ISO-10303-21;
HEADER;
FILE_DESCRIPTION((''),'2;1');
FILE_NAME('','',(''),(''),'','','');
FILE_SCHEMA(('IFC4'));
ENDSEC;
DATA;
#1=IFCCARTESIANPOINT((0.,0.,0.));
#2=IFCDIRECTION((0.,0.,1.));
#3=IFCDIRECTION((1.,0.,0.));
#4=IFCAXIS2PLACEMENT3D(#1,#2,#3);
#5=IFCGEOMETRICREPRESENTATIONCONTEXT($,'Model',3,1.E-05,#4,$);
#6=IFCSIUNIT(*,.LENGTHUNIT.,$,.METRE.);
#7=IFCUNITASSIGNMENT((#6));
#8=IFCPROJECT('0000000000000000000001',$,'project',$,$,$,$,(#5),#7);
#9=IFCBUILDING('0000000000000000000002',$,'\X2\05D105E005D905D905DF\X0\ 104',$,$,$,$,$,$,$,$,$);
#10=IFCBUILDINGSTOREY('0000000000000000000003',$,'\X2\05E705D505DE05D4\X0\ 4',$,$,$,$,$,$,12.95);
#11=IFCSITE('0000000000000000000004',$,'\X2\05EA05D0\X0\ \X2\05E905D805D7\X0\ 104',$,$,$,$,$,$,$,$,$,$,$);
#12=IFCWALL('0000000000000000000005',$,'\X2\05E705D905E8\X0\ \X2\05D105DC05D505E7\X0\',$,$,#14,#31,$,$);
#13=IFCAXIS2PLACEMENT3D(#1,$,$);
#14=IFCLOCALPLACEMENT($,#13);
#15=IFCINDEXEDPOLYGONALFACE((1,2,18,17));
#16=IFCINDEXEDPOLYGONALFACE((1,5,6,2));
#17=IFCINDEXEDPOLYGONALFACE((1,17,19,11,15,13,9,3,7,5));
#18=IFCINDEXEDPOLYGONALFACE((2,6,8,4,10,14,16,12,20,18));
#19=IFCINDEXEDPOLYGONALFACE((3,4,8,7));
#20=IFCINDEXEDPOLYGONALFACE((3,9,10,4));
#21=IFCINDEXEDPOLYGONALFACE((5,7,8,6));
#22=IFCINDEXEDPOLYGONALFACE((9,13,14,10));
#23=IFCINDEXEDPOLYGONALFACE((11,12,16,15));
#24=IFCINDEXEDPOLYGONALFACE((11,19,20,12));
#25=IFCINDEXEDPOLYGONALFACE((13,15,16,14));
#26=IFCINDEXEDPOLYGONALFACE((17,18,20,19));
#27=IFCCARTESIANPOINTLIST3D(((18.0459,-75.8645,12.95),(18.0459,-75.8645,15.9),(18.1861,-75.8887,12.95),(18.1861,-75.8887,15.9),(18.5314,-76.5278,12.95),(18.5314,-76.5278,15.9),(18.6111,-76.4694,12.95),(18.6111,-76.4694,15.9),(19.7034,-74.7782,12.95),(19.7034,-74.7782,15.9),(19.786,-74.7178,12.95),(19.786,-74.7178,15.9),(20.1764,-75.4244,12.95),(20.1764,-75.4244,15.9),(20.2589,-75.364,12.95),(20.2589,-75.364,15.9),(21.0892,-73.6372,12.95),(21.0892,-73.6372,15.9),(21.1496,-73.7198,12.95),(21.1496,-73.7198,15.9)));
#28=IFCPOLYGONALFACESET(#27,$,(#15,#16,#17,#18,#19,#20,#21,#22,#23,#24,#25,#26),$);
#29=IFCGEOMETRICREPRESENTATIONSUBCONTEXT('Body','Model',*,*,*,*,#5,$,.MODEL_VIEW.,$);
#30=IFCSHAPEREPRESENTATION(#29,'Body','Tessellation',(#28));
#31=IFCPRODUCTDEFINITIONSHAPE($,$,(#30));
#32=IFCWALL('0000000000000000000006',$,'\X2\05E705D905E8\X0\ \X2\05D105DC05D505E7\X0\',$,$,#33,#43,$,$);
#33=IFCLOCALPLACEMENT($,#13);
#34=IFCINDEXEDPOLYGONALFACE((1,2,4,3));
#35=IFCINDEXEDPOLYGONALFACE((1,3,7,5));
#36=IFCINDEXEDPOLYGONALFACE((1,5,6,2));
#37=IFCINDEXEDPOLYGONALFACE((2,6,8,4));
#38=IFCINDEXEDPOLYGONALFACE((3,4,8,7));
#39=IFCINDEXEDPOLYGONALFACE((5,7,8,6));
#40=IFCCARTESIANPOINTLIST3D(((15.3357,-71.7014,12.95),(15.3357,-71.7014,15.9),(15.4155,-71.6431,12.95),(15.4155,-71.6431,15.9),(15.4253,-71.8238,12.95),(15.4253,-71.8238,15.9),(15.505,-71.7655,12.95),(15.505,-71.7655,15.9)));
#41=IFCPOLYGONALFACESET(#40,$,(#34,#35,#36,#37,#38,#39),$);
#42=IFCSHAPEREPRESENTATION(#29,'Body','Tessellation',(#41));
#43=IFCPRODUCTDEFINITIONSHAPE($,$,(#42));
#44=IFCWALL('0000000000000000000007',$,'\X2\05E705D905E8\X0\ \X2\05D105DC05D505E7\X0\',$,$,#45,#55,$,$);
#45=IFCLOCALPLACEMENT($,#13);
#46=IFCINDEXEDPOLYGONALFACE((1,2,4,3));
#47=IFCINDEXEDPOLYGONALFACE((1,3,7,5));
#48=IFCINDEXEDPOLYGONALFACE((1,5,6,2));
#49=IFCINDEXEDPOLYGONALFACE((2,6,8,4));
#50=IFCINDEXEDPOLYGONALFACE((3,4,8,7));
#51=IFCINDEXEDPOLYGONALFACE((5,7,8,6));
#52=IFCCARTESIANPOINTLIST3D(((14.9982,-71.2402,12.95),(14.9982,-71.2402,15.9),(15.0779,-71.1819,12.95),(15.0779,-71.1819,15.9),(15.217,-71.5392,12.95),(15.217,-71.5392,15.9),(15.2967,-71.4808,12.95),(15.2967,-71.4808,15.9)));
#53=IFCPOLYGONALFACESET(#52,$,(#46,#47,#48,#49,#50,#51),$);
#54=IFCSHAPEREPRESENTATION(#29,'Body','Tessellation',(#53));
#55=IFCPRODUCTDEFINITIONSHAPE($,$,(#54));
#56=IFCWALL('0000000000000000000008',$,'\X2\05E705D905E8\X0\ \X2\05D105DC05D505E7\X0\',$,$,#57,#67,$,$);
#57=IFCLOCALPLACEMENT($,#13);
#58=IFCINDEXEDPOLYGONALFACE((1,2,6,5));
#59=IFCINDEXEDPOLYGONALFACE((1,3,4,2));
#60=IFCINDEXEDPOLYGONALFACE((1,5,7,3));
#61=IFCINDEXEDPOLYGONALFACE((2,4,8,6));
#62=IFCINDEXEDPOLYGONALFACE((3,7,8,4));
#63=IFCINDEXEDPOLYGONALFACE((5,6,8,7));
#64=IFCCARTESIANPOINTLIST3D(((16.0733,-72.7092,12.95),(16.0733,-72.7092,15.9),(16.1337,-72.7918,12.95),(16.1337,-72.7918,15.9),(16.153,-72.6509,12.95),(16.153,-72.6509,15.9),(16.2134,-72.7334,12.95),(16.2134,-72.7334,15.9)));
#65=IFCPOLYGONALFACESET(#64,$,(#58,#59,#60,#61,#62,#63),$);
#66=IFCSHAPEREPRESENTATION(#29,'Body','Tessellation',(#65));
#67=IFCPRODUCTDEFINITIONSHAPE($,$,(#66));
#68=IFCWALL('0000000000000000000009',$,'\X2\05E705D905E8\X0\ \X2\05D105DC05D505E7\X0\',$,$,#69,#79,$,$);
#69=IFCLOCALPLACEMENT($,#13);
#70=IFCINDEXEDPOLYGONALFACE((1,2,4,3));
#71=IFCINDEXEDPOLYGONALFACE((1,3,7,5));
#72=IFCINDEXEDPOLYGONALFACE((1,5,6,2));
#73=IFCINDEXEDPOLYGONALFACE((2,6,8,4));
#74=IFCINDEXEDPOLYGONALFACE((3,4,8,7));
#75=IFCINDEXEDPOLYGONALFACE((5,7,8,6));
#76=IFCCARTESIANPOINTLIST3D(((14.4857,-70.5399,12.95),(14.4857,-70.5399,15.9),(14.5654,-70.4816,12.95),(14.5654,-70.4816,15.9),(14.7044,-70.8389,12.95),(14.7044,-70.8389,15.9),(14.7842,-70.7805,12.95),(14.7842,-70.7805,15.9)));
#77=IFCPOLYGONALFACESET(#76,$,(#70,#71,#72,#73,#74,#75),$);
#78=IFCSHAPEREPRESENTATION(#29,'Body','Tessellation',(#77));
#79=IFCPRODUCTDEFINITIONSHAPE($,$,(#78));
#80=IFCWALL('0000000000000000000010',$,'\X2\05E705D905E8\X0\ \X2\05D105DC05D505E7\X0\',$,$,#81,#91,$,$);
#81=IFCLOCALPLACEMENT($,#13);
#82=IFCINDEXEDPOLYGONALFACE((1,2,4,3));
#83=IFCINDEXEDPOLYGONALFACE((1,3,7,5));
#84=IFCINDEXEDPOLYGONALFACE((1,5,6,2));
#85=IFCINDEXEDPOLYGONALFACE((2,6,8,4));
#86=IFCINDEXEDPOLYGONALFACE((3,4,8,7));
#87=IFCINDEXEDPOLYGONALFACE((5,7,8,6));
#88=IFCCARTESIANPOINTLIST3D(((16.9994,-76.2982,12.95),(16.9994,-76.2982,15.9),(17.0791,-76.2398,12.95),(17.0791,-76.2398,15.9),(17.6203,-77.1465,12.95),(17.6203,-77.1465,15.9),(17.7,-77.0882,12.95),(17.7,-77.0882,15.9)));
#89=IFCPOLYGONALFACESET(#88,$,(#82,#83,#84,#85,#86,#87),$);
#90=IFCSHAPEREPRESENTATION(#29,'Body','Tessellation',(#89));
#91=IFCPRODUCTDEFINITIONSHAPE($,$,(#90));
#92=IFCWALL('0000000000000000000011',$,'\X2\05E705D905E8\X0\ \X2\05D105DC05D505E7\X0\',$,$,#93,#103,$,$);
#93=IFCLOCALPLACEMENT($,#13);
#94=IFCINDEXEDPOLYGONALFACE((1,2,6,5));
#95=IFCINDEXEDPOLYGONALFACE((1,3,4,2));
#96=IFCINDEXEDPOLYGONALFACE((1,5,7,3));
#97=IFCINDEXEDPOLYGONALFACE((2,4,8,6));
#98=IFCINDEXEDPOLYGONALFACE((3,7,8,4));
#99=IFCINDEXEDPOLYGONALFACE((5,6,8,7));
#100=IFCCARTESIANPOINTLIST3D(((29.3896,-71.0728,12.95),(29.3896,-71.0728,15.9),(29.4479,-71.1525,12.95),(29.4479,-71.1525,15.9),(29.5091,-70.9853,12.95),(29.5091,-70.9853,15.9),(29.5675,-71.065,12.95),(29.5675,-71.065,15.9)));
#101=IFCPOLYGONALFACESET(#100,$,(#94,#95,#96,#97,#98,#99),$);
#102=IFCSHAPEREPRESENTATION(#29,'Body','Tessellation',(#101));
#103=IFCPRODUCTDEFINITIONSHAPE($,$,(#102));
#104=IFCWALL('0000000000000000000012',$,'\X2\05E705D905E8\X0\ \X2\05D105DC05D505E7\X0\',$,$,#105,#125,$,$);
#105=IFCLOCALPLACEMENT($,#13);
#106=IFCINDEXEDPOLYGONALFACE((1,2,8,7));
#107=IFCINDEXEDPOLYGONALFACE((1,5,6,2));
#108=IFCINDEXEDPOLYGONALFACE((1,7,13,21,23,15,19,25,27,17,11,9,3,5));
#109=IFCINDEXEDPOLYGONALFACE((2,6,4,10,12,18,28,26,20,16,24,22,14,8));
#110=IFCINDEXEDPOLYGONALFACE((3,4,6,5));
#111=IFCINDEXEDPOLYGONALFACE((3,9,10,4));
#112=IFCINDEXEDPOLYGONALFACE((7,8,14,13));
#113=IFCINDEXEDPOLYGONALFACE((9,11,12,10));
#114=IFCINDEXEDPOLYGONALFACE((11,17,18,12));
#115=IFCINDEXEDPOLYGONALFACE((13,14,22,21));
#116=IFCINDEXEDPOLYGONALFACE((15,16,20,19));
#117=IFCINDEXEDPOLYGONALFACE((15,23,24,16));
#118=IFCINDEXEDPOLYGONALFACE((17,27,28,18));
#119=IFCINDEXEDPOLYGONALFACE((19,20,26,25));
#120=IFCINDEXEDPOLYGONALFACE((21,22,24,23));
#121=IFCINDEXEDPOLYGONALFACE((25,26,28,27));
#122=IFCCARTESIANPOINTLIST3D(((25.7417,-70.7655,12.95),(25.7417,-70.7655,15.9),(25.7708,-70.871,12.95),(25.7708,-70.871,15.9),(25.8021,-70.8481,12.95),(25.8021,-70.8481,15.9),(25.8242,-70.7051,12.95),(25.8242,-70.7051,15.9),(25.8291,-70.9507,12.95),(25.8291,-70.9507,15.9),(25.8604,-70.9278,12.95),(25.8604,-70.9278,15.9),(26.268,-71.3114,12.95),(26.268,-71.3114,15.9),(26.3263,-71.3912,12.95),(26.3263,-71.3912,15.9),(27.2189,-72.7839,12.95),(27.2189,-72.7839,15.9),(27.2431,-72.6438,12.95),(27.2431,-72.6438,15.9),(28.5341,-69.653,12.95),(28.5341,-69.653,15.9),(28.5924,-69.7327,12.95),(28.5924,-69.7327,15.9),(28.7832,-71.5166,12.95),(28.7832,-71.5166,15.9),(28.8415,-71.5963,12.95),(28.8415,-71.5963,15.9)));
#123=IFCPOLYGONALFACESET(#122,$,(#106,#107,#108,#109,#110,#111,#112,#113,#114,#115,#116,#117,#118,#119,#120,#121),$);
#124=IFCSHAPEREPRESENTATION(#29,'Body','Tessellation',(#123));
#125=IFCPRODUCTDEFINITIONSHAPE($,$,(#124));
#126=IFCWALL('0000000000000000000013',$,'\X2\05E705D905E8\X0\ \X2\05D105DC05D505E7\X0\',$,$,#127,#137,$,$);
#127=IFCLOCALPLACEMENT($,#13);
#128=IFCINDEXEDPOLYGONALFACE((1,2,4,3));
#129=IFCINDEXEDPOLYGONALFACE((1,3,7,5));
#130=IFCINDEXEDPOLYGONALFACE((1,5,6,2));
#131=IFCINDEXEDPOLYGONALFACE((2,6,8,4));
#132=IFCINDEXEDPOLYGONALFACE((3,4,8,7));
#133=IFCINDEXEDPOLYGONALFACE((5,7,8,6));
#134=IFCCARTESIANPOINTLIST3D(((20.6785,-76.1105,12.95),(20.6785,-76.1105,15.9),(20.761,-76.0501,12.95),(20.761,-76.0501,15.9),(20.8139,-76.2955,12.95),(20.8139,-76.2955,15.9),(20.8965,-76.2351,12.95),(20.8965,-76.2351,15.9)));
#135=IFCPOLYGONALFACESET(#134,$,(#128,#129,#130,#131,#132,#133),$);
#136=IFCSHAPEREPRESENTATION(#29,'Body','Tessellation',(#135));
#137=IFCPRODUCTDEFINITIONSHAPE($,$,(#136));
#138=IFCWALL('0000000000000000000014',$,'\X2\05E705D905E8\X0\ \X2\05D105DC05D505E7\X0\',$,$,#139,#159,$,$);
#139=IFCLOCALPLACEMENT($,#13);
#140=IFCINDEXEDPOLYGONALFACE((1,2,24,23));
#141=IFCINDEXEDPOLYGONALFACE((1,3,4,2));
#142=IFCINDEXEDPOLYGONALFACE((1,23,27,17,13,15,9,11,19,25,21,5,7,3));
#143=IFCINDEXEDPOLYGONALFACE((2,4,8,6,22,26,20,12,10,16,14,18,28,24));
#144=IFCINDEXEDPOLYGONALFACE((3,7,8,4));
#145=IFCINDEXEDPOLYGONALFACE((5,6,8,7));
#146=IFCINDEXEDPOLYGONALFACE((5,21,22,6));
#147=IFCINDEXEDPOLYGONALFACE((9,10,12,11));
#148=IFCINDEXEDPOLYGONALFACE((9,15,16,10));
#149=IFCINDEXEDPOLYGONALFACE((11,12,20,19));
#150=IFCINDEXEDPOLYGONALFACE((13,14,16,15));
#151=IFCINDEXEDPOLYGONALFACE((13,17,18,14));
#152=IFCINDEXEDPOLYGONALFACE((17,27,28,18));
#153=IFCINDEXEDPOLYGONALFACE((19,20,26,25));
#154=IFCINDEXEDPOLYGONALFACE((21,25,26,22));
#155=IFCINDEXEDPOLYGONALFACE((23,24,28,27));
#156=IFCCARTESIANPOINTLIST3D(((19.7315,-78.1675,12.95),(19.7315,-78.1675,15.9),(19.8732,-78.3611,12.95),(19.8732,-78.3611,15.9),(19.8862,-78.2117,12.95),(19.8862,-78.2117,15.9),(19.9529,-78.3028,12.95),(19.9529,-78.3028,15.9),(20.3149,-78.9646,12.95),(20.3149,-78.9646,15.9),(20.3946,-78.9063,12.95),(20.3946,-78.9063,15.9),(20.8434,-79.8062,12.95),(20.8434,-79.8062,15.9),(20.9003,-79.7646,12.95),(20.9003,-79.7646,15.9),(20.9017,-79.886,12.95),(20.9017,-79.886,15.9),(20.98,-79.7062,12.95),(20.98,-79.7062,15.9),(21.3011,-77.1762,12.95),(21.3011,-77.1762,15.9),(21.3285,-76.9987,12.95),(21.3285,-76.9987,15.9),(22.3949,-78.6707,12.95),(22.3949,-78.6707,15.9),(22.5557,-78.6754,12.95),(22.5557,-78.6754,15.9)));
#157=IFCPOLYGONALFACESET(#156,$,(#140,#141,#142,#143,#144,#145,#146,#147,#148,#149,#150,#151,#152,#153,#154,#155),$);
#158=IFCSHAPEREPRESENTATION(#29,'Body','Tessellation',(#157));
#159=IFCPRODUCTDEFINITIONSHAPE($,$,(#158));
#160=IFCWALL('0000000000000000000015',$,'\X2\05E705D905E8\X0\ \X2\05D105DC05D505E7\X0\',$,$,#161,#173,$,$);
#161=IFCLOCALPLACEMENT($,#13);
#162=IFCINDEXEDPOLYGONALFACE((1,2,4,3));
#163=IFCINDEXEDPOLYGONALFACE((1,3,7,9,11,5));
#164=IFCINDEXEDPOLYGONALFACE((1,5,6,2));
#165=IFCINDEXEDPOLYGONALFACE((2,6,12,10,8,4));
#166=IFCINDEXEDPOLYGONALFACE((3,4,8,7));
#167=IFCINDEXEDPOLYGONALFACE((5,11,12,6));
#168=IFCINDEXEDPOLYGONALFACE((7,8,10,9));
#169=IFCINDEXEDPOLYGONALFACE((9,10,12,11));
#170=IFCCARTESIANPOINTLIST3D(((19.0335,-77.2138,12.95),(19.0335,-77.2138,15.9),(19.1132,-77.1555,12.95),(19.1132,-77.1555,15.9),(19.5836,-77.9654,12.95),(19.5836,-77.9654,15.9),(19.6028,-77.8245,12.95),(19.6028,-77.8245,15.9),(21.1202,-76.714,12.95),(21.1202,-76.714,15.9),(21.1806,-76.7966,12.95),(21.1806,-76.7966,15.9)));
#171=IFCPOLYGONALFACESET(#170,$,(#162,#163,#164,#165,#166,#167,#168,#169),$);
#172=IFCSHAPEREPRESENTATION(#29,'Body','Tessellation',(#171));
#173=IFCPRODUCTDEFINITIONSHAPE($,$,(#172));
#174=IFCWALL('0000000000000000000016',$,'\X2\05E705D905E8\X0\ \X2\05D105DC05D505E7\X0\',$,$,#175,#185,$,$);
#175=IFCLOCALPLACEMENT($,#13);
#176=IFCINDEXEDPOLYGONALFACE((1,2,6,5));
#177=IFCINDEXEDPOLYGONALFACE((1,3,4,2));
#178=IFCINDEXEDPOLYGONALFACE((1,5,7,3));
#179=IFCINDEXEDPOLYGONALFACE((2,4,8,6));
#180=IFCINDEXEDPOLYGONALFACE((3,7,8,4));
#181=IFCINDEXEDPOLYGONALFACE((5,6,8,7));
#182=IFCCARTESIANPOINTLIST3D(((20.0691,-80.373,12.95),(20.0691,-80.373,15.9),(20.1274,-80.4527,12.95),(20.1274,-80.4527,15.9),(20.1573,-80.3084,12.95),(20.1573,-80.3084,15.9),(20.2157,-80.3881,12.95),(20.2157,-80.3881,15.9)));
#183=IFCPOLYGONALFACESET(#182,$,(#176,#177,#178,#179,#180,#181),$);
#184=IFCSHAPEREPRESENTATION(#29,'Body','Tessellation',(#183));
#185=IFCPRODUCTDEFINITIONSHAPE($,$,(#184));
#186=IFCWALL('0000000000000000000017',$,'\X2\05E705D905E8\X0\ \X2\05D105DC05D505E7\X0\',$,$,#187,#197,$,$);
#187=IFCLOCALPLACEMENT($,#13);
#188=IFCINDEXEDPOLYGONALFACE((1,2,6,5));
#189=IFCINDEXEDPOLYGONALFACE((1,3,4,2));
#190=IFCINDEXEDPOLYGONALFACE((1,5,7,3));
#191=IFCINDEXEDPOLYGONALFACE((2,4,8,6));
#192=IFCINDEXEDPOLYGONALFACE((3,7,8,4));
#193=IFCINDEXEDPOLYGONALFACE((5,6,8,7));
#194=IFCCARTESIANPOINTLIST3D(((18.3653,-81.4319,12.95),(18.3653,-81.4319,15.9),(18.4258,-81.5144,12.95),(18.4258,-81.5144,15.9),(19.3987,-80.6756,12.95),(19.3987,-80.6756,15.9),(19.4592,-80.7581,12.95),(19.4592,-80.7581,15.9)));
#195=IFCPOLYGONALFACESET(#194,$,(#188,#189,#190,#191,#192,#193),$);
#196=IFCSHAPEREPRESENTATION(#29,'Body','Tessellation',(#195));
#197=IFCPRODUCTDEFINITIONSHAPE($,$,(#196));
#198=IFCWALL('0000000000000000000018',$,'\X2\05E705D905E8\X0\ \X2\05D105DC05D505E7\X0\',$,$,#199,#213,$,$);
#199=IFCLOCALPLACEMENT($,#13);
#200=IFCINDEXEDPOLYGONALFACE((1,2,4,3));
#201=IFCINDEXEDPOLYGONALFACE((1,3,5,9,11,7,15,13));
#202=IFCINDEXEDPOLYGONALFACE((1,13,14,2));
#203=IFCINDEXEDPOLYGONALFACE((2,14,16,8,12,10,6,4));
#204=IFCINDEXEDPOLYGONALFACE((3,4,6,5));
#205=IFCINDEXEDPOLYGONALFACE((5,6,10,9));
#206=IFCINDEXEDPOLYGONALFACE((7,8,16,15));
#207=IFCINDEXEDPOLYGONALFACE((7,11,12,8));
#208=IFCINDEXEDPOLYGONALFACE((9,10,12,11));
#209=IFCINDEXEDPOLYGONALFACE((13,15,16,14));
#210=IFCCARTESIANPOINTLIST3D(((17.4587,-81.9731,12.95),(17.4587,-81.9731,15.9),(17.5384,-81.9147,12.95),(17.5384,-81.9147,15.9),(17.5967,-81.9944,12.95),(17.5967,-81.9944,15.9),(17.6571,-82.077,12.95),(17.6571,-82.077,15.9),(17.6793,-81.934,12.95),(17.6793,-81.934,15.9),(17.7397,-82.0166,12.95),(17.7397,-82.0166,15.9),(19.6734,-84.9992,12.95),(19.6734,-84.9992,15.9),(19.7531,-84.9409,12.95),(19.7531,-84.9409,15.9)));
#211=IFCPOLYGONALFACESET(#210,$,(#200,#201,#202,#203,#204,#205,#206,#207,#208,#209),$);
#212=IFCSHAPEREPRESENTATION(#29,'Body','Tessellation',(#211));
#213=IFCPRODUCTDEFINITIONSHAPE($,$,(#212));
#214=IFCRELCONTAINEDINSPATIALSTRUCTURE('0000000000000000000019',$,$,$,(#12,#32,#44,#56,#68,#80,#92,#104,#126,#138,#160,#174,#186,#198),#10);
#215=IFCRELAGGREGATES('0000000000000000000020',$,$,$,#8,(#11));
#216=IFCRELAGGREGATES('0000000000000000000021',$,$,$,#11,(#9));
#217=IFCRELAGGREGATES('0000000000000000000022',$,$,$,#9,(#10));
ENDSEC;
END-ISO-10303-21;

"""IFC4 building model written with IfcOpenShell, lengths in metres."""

from ifc_helpers import new_model, si_unit, frame, origin_with_axes, context, subcontext, project, spatial, polyline, outline, extrude, element, save


model = new_model("IFC4")

# Units and contexts
model_context = context("Model", 3, precision=1e-05, world=origin_with_axes())
body_context = subcontext(model_context, "Body", "Model", "MODEL_VIEW")
ifc_project = project(units=[si_unit("LENGTHUNIT", "METRE")], contexts=[model_context])

# Site, building, storey
site = spatial("IfcSite", under=ifc_project, Name="תא שטח 104")
building = spatial("IfcBuilding", under=site, Name="בניין 104")
storey = spatial("IfcBuildingStorey", under=building, Name="קומה 4", Elevation=12.95)

# Walls
element("IfcWall", 1, inside=storey, Name="קיר בלוק", context=body_context, shape_type="SweptSolid", body=[
    extrude(outline(polyline([(19.7034, -74.7782), (20.1764, -75.4244), (20.2589, -75.364), (19.786, -74.7178), (21.1496, -73.7198), (21.0892, -73.6372), (18.0459, -75.8645), (18.5314, -76.5278), (18.6111, -76.4694), (18.1861, -75.8887), (19.7034, -74.7782)])), frame((0.0, 0.0, 12.95)), (0.0, 0.0, 1.0), 2.95),
])
element("IfcWall", 2, inside=storey, Name="קיר בלוק", context=body_context, shape_type="SweptSolid", body=[
    extrude(outline(polyline([(15.3357, -71.7014), (15.4253, -71.8238), (15.505, -71.7655), (15.4155, -71.6431), (15.3357, -71.7014)])), frame((0.0, 0.0, 12.95)), (0.0, 0.0, 1.0), 2.95),
])
element("IfcWall", 3, inside=storey, Name="קיר בלוק", context=body_context, shape_type="SweptSolid", body=[
    extrude(outline(polyline([(15.0779, -71.1819), (14.9982, -71.2403), (15.217, -71.5392), (15.2967, -71.4808), (15.0779, -71.1819)])), frame((0.0, 0.0, 12.95)), (0.0, 0.0, 1.0), 2.95),
])
element("IfcWall", 4, inside=storey, Name="קיר בלוק", context=body_context, shape_type="SweptSolid", body=[
    extrude(outline(polyline([(16.2134, -72.7334), (16.153, -72.6509), (16.0733, -72.7092), (16.1337, -72.7918), (16.2134, -72.7334)])), frame((0.0, 0.0, 12.95)), (0.0, 0.0, 1.0), 2.95),
])
element("IfcWall", 5, inside=storey, Name="קיר בלוק", context=body_context, shape_type="SweptSolid", body=[
    extrude(outline(polyline([(14.7044, -70.8389), (14.7841, -70.7805), (14.5654, -70.4816), (14.4857, -70.5399), (14.7044, -70.8389)])), frame((0.0, 0.0, 12.95)), (0.0, 0.0, 1.0), 2.95),
])
element("IfcWall", 6, inside=storey, Name="קיר בלוק", context=body_context, shape_type="SweptSolid", body=[
    extrude(outline(polyline([(17.6203, -77.1465), (17.7, -77.0882), (17.0791, -76.2398), (16.9994, -76.2982), (17.6203, -77.1465)])), frame((0.0, 0.0, 12.95)), (0.0, 0.0, 1.0), 2.95),
])
element("IfcWall", 7, inside=storey, Name="קיר בלוק", context=body_context, shape_type="SweptSolid", body=[
    extrude(outline(polyline([(29.5675, -71.065), (29.5091, -70.9853), (29.3896, -71.0728), (29.4479, -71.1525), (29.5675, -71.065)])), frame((0.0, 0.0, 12.95)), (0.0, 0.0, 1.0), 2.95),
])
element("IfcWall", 8, inside=storey, Name="קיר בלוק", context=body_context, shape_type="SweptSolid", body=[
    extrude(outline(polyline([(25.8021, -70.8481), (25.7708, -70.871), (25.8291, -70.9507), (25.8604, -70.9278), (27.2189, -72.7839), (28.8415, -71.5963), (28.7832, -71.5166), (27.2431, -72.6438), (26.3263, -71.3912), (28.5924, -69.7327), (28.5341, -69.653), (26.268, -71.3114), (25.8242, -70.7051), (25.7417, -70.7655), (25.8021, -70.8481)])), frame((0.0, 0.0, 12.95)), (0.0, 0.0, 1.0), 2.95),
])
element("IfcWall", 9, inside=storey, Name="קיר בלוק", context=body_context, shape_type="SweptSolid", body=[
    extrude(outline(polyline([(20.8965, -76.2351), (20.761, -76.0501), (20.6785, -76.1105), (20.8139, -76.2955), (20.8965, -76.2351)])), frame((0.0, 0.0, 12.95)), (0.0, 0.0, 1.0), 2.95),
])
element("IfcWall", 10, inside=storey, Name="קיר בלוק", context=body_context, shape_type="SweptSolid", body=[
    extrude(outline(polyline([(21.3285, -76.9987), (19.7315, -78.1675), (19.8732, -78.3611), (19.9529, -78.3028), (19.8862, -78.2117), (21.3011, -77.1762), (22.3949, -78.6707), (20.98, -79.7062), (20.3946, -78.9063), (20.3149, -78.9646), (20.9003, -79.7646), (20.8434, -79.8062), (20.9017, -79.886), (22.5557, -78.6754), (21.3285, -76.9987)])), frame((0.0, 0.0, 12.95)), (0.0, 0.0, 1.0), 2.95),
])
element("IfcWall", 11, inside=storey, Name="קיר בלוק", context=body_context, shape_type="SweptSolid", body=[
    extrude(outline(polyline([(19.0335, -77.2138), (19.5836, -77.9654), (21.1806, -76.7966), (21.1202, -76.714), (19.6028, -77.8245), (19.1132, -77.1555), (19.0335, -77.2138)])), frame((0.0, 0.0, 12.95)), (0.0, 0.0, 1.0), 2.95),
])
element("IfcWall", 12, inside=storey, Name="קיר בלוק", context=body_context, shape_type="SweptSolid", body=[
    extrude(outline(polyline([(20.2157, -80.3881), (20.1573, -80.3084), (20.0691, -80.373), (20.1274, -80.4527), (20.2157, -80.3881)])), frame((0.0, 0.0, 12.95)), (0.0, 0.0, 1.0), 2.95),
])
element("IfcWall", 13, inside=storey, Name="קיר בלוק", context=body_context, shape_type="SweptSolid", body=[
    extrude(outline(polyline([(19.4592, -80.7581), (19.3987, -80.6756), (18.3653, -81.4319), (18.4258, -81.5144), (19.4592, -80.7581)])), frame((0.0, 0.0, 12.95)), (0.0, 0.0, 1.0), 2.95),
])
element("IfcWall", 14, inside=storey, Name="קיר בלוק", context=body_context, shape_type="SweptSolid", body=[
    extrude(outline(polyline([(17.4587, -81.9731), (19.6734, -84.9992), (19.7531, -84.9409), (17.6571, -82.077), (17.7397, -82.0166), (17.6793, -81.934), (17.5967, -81.9944), (17.5384, -81.9147), (17.4587, -81.9731)])), frame((0.0, 0.0, 12.95)), (0.0, 0.0, 1.0), 2.95),
])

save(model, "model.ifc")
